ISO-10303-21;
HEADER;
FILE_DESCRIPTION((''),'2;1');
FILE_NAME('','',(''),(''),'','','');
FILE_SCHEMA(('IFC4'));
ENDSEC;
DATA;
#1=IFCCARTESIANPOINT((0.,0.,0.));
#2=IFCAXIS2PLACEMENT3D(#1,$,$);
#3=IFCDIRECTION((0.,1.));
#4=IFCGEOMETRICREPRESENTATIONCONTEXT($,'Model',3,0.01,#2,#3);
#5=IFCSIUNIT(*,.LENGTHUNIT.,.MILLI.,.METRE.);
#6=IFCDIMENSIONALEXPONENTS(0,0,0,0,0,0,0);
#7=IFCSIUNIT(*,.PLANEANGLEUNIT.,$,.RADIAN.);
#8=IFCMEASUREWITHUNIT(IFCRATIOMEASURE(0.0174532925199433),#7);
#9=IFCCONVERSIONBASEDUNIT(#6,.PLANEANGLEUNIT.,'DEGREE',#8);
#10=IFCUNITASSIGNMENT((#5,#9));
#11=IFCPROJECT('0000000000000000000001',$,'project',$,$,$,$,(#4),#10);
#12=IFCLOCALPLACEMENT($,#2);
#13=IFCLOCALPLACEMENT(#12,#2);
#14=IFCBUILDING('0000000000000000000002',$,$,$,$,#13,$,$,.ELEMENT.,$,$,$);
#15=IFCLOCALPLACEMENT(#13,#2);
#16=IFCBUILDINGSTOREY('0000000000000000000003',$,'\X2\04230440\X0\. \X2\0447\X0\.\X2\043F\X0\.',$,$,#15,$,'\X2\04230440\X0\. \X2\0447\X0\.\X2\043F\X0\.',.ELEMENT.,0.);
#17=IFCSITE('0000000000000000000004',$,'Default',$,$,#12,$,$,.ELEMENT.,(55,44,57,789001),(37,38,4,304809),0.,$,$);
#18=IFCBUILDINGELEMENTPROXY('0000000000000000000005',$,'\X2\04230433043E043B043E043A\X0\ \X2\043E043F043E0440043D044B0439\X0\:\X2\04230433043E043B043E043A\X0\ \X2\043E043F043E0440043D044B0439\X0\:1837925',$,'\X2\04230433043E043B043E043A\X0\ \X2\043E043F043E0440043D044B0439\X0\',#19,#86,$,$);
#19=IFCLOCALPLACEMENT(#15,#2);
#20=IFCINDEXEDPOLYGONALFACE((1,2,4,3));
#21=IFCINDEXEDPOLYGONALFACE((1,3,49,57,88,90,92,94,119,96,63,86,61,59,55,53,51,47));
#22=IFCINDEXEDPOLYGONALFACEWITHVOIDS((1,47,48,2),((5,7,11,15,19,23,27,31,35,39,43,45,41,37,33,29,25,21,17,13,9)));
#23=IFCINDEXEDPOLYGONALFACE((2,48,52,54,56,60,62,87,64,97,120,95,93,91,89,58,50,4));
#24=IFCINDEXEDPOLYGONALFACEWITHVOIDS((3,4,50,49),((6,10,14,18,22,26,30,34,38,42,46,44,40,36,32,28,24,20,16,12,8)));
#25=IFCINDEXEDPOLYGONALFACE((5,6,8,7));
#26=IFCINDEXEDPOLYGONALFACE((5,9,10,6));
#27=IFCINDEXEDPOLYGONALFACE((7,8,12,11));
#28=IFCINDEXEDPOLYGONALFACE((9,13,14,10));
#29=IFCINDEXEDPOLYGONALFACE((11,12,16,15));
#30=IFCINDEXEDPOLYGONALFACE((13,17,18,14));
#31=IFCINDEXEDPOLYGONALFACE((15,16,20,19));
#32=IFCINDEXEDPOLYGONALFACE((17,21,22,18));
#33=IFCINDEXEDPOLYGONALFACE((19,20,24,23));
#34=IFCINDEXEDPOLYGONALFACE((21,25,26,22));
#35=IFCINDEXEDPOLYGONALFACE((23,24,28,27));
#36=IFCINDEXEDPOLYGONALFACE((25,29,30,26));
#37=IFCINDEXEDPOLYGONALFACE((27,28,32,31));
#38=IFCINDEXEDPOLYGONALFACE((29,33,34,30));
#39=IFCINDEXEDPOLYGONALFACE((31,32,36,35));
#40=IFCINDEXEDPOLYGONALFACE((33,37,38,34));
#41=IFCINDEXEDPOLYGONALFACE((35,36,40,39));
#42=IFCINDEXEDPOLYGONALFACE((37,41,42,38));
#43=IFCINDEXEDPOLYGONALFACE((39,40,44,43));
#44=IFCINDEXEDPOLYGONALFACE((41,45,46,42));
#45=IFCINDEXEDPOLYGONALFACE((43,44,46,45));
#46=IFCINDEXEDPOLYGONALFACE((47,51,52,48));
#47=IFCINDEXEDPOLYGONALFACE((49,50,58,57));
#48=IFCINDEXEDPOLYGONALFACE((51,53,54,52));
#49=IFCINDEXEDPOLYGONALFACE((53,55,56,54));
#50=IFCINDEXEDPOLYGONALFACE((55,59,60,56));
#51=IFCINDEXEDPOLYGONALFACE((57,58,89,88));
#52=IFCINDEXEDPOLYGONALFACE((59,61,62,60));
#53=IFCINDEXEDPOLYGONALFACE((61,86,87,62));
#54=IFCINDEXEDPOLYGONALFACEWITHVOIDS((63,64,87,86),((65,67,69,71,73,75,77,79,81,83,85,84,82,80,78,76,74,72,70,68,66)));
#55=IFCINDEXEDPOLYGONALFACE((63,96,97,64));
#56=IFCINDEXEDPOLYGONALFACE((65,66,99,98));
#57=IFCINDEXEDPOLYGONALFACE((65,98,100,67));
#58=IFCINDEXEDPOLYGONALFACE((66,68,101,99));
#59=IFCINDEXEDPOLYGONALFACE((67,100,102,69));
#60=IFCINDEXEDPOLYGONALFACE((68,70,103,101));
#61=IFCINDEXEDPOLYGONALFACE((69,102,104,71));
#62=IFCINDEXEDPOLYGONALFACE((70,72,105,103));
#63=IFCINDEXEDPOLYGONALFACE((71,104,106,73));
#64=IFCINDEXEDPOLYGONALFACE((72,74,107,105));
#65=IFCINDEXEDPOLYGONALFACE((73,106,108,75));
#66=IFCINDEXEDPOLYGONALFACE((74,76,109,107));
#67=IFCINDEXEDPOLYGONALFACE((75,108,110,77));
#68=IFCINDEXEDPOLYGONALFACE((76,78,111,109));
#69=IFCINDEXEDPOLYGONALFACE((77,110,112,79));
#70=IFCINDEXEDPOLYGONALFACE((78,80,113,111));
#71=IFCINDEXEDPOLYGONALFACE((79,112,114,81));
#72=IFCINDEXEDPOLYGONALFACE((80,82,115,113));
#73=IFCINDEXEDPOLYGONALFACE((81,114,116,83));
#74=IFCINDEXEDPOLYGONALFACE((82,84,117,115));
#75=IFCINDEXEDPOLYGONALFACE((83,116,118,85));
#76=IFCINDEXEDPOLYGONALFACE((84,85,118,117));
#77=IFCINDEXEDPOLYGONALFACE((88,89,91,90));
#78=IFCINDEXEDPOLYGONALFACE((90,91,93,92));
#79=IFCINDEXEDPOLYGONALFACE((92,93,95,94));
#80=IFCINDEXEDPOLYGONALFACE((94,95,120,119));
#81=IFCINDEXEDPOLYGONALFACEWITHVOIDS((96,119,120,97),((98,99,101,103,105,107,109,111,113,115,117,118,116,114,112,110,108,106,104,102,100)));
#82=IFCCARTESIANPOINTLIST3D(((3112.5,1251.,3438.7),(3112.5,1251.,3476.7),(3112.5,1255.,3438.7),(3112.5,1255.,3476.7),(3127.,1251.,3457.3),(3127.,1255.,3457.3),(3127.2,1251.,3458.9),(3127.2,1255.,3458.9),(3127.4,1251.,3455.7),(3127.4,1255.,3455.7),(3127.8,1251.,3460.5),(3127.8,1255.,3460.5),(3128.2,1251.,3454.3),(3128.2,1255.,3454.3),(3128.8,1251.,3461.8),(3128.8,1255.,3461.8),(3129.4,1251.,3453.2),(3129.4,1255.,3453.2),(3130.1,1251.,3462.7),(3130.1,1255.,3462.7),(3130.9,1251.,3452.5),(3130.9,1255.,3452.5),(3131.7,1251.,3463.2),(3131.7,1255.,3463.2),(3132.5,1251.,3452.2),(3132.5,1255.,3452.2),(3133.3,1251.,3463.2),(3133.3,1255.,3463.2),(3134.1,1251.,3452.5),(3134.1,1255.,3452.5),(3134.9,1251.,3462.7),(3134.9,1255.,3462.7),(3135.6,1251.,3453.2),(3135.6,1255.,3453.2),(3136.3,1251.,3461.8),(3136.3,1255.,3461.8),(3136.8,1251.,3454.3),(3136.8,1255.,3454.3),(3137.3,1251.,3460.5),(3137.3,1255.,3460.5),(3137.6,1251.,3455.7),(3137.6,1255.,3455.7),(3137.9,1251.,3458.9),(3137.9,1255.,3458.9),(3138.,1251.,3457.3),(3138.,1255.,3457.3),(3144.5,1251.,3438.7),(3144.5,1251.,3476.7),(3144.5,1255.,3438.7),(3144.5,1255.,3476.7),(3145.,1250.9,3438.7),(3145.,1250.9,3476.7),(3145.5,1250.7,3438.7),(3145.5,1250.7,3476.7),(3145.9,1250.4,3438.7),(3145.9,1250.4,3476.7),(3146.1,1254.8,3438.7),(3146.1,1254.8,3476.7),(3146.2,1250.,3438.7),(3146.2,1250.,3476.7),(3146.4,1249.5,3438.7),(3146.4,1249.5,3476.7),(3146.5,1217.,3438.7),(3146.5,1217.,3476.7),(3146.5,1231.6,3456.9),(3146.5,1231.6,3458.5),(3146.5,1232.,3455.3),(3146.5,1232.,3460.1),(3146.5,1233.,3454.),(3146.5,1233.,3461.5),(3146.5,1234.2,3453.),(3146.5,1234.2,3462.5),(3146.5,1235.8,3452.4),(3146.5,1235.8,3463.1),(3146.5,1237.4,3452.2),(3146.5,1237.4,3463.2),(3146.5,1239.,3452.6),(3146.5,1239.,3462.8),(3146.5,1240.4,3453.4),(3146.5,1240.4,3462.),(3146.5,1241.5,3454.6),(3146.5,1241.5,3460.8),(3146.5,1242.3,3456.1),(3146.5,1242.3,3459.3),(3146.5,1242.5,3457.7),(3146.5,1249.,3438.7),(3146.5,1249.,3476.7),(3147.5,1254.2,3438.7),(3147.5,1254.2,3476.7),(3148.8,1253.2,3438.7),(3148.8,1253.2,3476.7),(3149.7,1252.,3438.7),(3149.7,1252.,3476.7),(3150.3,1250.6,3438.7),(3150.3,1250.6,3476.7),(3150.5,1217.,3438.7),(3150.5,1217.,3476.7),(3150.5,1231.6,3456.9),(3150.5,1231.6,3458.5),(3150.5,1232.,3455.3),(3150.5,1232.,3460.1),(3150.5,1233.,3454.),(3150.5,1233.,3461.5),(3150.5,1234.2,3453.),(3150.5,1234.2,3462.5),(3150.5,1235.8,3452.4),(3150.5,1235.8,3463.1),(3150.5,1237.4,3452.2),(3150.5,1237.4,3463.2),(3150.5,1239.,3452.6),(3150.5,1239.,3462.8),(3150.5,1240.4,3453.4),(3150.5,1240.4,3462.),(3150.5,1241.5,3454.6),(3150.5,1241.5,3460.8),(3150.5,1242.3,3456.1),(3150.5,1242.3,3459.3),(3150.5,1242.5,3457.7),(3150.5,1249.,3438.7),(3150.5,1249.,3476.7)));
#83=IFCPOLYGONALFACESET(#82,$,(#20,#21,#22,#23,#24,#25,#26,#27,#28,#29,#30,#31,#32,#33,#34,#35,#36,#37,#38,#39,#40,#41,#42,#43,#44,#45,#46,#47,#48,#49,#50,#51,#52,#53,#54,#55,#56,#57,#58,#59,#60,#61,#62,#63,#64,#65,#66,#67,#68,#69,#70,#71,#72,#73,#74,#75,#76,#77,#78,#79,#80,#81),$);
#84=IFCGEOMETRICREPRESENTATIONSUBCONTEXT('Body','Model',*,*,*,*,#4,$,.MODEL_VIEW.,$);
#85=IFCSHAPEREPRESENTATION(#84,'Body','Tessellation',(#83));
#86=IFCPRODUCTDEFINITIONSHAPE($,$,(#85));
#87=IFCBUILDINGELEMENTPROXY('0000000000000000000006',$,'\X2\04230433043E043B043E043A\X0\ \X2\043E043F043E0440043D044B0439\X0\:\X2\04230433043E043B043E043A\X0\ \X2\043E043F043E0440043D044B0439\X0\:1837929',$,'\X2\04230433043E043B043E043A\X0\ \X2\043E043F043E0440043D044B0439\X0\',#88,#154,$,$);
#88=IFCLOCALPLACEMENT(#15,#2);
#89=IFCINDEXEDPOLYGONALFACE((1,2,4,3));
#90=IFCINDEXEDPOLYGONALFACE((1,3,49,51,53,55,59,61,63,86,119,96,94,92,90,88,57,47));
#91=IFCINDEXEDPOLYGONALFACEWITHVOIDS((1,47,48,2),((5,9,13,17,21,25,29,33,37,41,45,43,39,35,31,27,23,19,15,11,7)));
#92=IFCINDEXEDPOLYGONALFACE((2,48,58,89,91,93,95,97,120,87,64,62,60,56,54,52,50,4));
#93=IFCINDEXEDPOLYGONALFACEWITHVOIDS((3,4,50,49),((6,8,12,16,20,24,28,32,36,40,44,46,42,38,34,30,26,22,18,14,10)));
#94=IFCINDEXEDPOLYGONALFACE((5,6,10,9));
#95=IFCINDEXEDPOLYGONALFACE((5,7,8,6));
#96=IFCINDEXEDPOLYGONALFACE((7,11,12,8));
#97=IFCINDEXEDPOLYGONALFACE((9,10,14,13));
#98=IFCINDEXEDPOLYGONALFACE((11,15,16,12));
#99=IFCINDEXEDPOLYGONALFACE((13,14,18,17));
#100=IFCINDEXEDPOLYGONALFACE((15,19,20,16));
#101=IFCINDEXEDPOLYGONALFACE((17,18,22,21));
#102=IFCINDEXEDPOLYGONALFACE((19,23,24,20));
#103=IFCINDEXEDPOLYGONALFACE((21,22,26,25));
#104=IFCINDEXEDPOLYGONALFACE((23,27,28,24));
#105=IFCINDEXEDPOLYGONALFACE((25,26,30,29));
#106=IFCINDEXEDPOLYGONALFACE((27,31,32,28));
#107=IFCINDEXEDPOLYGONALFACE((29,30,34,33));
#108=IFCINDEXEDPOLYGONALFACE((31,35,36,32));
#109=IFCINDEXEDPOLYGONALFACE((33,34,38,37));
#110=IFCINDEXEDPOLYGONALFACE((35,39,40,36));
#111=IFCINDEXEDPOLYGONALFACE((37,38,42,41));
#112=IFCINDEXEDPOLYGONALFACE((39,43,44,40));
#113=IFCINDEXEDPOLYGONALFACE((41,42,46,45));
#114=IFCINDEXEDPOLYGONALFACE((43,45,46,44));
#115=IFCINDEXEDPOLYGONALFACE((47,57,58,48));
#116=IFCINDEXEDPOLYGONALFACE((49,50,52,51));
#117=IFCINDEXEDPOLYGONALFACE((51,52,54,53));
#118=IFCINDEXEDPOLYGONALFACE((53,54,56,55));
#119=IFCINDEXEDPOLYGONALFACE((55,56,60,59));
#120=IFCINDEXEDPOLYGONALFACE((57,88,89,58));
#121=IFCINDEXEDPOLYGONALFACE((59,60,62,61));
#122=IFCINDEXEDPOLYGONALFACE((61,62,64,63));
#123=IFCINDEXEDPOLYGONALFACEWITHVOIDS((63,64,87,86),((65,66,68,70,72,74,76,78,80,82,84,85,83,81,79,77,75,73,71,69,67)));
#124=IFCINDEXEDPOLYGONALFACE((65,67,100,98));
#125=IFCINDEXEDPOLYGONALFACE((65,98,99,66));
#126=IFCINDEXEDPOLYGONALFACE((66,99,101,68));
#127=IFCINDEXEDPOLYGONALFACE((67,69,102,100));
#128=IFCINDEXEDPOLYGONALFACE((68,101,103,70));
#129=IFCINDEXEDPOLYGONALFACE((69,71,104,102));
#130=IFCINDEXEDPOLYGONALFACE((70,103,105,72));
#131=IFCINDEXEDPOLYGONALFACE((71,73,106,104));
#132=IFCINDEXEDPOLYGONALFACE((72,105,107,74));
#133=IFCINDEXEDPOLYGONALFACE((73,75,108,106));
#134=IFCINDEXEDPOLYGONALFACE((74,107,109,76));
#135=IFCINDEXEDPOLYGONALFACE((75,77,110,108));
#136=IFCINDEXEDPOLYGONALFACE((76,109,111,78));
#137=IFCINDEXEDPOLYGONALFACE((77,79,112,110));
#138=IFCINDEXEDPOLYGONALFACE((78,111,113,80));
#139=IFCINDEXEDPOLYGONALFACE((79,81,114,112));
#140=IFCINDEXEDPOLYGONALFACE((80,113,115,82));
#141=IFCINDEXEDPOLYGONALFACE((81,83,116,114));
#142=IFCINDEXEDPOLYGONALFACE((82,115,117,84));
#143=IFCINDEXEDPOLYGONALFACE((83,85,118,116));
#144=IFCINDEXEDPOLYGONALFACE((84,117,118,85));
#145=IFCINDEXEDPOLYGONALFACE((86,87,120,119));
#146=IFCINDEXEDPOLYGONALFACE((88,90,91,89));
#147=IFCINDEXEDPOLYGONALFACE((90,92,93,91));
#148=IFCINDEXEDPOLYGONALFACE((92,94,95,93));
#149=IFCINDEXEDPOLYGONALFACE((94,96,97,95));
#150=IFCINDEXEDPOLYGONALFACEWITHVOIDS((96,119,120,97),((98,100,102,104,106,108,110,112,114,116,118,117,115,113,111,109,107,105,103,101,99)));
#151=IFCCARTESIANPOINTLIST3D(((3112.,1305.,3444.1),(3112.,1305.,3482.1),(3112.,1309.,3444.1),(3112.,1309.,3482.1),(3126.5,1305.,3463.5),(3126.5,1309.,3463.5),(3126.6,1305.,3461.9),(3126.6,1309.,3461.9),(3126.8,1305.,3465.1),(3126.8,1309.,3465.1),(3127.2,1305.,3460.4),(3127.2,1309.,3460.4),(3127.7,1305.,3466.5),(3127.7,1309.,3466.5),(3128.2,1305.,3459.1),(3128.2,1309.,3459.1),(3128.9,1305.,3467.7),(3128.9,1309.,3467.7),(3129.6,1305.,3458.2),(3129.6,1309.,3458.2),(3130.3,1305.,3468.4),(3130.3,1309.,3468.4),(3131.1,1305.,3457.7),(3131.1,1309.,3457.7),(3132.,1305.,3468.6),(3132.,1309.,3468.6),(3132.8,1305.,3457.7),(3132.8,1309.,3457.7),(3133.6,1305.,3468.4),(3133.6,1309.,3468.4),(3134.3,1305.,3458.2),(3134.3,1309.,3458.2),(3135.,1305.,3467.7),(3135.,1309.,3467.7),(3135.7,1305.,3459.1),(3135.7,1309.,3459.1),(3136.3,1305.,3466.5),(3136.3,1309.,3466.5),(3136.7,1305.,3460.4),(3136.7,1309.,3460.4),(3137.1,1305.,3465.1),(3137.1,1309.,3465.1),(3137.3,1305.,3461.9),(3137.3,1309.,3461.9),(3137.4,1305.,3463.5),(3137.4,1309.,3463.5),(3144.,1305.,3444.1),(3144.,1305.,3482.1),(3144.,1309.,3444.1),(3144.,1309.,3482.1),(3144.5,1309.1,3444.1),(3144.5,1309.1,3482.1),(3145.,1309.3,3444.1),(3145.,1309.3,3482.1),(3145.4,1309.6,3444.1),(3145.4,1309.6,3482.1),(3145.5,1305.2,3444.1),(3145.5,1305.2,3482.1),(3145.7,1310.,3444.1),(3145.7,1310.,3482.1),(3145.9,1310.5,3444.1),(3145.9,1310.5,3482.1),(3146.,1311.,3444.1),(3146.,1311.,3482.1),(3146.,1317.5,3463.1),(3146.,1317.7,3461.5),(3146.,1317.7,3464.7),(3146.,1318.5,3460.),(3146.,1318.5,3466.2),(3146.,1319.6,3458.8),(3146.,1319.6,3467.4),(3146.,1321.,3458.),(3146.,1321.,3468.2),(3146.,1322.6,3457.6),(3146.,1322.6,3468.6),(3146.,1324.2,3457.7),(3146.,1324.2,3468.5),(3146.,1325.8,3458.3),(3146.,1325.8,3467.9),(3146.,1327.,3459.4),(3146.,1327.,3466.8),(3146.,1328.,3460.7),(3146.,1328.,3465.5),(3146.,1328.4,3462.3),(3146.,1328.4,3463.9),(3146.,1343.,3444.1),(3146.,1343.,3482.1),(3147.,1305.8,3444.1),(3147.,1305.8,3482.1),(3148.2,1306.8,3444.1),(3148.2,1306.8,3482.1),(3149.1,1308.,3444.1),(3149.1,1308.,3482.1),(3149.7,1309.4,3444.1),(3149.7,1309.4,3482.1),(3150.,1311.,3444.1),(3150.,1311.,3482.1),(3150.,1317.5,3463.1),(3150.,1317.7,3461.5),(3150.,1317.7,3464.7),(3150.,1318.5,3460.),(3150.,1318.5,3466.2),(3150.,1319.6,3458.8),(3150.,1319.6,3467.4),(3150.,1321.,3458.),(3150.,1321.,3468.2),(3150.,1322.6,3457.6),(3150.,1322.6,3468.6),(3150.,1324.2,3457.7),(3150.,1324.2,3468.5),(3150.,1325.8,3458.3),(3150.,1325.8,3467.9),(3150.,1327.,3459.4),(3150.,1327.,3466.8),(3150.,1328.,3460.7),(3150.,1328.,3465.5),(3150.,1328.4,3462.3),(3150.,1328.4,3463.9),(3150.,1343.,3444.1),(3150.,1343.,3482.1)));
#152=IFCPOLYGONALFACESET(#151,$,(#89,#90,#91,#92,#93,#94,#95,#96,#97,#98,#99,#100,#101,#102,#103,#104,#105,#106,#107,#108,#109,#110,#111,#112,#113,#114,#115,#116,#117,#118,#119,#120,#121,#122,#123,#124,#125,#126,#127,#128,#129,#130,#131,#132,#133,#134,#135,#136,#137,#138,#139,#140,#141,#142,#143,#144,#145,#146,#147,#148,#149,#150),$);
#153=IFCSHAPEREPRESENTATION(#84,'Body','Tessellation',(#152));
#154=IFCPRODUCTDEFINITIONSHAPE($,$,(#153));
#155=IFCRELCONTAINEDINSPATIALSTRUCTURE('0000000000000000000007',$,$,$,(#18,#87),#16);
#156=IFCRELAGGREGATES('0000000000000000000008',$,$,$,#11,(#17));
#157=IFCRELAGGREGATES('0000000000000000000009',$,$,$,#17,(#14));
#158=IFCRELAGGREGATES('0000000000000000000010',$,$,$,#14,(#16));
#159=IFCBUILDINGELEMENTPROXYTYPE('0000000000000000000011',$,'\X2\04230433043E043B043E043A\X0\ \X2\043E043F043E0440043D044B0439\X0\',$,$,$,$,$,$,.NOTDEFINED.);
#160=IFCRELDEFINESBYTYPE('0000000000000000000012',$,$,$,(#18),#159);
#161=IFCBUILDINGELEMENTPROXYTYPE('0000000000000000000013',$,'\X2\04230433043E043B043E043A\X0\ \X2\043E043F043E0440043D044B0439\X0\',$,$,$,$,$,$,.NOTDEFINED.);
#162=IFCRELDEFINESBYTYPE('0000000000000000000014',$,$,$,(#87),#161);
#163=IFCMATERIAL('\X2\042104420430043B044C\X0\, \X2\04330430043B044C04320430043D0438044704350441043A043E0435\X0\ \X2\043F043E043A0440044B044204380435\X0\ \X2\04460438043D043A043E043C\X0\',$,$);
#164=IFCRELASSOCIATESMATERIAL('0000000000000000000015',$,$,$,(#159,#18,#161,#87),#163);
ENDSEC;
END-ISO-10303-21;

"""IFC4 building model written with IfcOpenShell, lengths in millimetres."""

from ifc_helpers import new_model, entity, si_unit, converted_unit, direction, frame, frame_2d, origin, place, context, subcontext, project, spatial, polyline, circle_curve, parameter, trimmed, segment, composite_curve, circle, outline, extrude, source, transform, mapped, material, type_object, type_shapes, element, save


model = new_model("IFC4")

# Units and contexts
model_context = context("Model", 3, precision=0.01, world=origin(), true_north=direction((0.0, 1.0)))
body_context = subcontext(model_context, "Body", "Model", "MODEL_VIEW")
ifc_project = project(units=[si_unit("LENGTHUNIT", "METRE", prefix="MILLI"), converted_unit("PLANEANGLEUNIT", "DEGREE", entity("IfcRatioMeasure", 0.0174532925199433), si_unit("PLANEANGLEUNIT", "RADIAN"), dimensions=[0, 0, 0, 0, 0, 0, 0])], contexts=[model_context])

# Site, building, storey
site_placement = place(None, origin())
site = spatial("IfcSite", under=ifc_project, at=site_placement, Name="Default", CompositionType="ELEMENT", RefLatitude=(55, 44, 57, 789001), RefLongitude=(37, 38, 4, 304809), RefElevation=0.0)
building_placement = place(site_placement, origin())
building = spatial("IfcBuilding", under=site, at=building_placement, CompositionType="ELEMENT")
storey_placement = place(building_placement, origin())
storey = spatial("IfcBuildingStorey", under=building, at=storey_placement, Name="Ур. ч.п.", LongName="Ур. ч.п.", CompositionType="ELEMENT", Elevation=0.0)

# Building element proxies, openings
ifc_material = material(Name="Сталь, гальваническое покрытие цинком")
building_element_proxy_type_1 = type_object("IfcBuildingElementProxyType", Name="Уголок опорный", material=ifc_material)
shared_shape_1 = source(origin(), body_context, "Body", "SweptSolid", [
    extrude(outline(composite_curve([segment(polyline([(-6.0, -12.0), (26.0, -12.0)]), True, "CONTINUOUS"), segment(polyline([(26.0, -12.0), (26.0, -8.0)]), True, "CONTINUOUS"), segment(polyline([(26.0, -8.0), (-6.0, -8.0)]), True, "CONTINUOUS"), segment(trimmed(circle_curve(frame_2d((-6.0, -6.0), x_axis=(0.0, -1.0)), 2.0), [parameter(270.0)], [parameter(0.0)], True, "PARAMETER"), False, "CONTINUOUS"), segment(polyline([(-8.0, -6.0), (-8.0, 26.0)]), True, "CONTINUOUS"), segment(polyline([(-8.0, 26.0), (-12.0, 26.0)]), True, "CONTINUOUS"), segment(polyline([(-12.0, 26.0), (-12.0, -6.0)]), True, "CONTINUOUS"), segment(trimmed(circle_curve(frame_2d((-6.0, -6.0), x_axis=(0.0, -1.0)), 6.0), [parameter(270.0)], [parameter(360.0)], True, "PARAMETER"), True, "CONTINUOUS")], self_intersect=False)), frame((12.0, -19.0, 12.0), z_axis=(0.0, 1.0, 0.0), x_axis=(0.0, 0.0, 1.0)), (0.0, 0.0, 1.0), 38.0),
])
type_shapes(building_element_proxy_type_1, [shared_shape_1])
proxy_1_placement = place(storey_placement, frame((3150.5, 1255.0, 3457.7), z_axis=(0.0, -1.0, 0.0), x_axis=(-1.0, 0.0, 0.0)))
proxy_1 = element("IfcBuildingElementProxy", 1, at=proxy_1_placement, inside=storey, type_object=building_element_proxy_type_1, material=ifc_material, Name="Уголок опорный:Уголок опорный:1837925", ObjectType="Уголок опорный", context=body_context, shape_type="MappedRepresentation", body=[
    mapped(shared_shape_1, transform((0.0, 0.0, 0.0), scale=1.0)),
])
opening_1_placement = place(storey_placement, frame((3150.5, 1255.0, 3457.7)))
element("IfcOpeningElement", 2, at=opening_1_placement, cuts=proxy_1, ObjectType="Opening", PredefinedType="OPENING", context=body_context, shape_type="SweptSolid", body=[
    extrude(circle(Radius=5.5, at=frame_2d((0.0, 0.0), x_axis=(1.0, 0.0))), frame((0.0, -18.0, 0.0), z_axis=(-1.0, 0.0, 0.0), x_axis=(0.0, 1.0, 0.0)), (0.0, 0.0, 1.0), 4.0),
])
opening_2_placement = place(storey_placement, frame((3150.5, 1255.0, 3457.7)))
element("IfcOpeningElement", 3, at=opening_2_placement, cuts=proxy_1, ObjectType="Opening", PredefinedType="OPENING", context=body_context, shape_type="SweptSolid", body=[
    extrude(circle(Radius=5.5, at=frame_2d((0.0, 0.0), x_axis=(1.0, 0.0))), frame((-18.0, 0.0, 0.0), z_axis=(0.0, -1.0, 0.0), x_axis=(0.0, 0.0, -1.0)), (0.0, 0.0, 1.0), 4.0),
])
building_element_proxy_type_2 = type_object("IfcBuildingElementProxyType", Name="Уголок опорный", material=ifc_material)
shared_shape_2 = source(origin(), body_context, "Body", "SweptSolid", [
    extrude(outline(composite_curve([segment(polyline([(-6.0, -12.0), (26.0, -12.0)]), True, "CONTINUOUS"), segment(polyline([(26.0, -12.0), (26.0, -8.0)]), True, "CONTINUOUS"), segment(polyline([(26.0, -8.0), (-6.0, -8.0)]), True, "CONTINUOUS"), segment(trimmed(circle_curve(frame_2d((-6.0, -6.0), x_axis=(0.0, -1.0)), 2.0), [parameter(270.0)], [parameter(0.0)], True, "PARAMETER"), False, "CONTINUOUS"), segment(polyline([(-8.0, -6.0), (-8.0, 26.0)]), True, "CONTINUOUS"), segment(polyline([(-8.0, 26.0), (-12.0, 26.0)]), True, "CONTINUOUS"), segment(polyline([(-12.0, 26.0), (-12.0, -6.0)]), True, "CONTINUOUS"), segment(trimmed(circle_curve(frame_2d((-6.0, -6.0), x_axis=(0.0, -1.0)), 6.0), [parameter(270.0)], [parameter(360.0)], True, "PARAMETER"), True, "CONTINUOUS")], self_intersect=False)), frame((12.0, -19.0, 12.0), z_axis=(0.0, 1.0, 0.0), x_axis=(0.0, 0.0, 1.0)), (0.0, 0.0, 1.0), 38.0),
])
type_shapes(building_element_proxy_type_2, [shared_shape_2])
proxy_2_placement = place(storey_placement, frame((3150.0, 1305.0, 3463.1), z_axis=(0.0, 1.0, 0.0), x_axis=(-1.0, 0.0, 0.0)))
proxy_2 = element("IfcBuildingElementProxy", 4, at=proxy_2_placement, inside=storey, type_object=building_element_proxy_type_2, material=ifc_material, Name="Уголок опорный:Уголок опорный:1837929", ObjectType="Уголок опорный", context=body_context, shape_type="MappedRepresentation", body=[
    mapped(shared_shape_2, transform((0.0, 0.0, 0.0), scale=1.0)),
])
opening_3_placement = place(storey_placement, frame((3150.0, 1305.0, 3463.1)))
element("IfcOpeningElement", 5, at=opening_3_placement, cuts=proxy_2, ObjectType="Opening", PredefinedType="OPENING", context=body_context, shape_type="SweptSolid", body=[
    extrude(circle(Radius=5.5, at=frame_2d((0.0, 0.0), x_axis=(1.0, 0.0))), frame((-4.0, 18.0, 0.0), z_axis=(1.0, 0.0, 0.0), x_axis=(0.0, -1.0, 0.0)), (0.0, 0.0, 1.0), 4.0),
])
opening_4_placement = place(storey_placement, frame((3150.0, 1305.0, 3463.1)))
element("IfcOpeningElement", 6, at=opening_4_placement, cuts=proxy_2, ObjectType="Opening", PredefinedType="OPENING", context=body_context, shape_type="SweptSolid", body=[
    extrude(circle(Radius=5.5, at=frame_2d((0.0, 0.0), x_axis=(1.0, 0.0))), frame((-18.0, 0.0, 0.0), z_axis=(0.0, 1.0, 0.0), x_axis=(0.0, 0.0, 1.0)), (0.0, 0.0, 1.0), 4.0),
])

save(model, "model.ifc")
